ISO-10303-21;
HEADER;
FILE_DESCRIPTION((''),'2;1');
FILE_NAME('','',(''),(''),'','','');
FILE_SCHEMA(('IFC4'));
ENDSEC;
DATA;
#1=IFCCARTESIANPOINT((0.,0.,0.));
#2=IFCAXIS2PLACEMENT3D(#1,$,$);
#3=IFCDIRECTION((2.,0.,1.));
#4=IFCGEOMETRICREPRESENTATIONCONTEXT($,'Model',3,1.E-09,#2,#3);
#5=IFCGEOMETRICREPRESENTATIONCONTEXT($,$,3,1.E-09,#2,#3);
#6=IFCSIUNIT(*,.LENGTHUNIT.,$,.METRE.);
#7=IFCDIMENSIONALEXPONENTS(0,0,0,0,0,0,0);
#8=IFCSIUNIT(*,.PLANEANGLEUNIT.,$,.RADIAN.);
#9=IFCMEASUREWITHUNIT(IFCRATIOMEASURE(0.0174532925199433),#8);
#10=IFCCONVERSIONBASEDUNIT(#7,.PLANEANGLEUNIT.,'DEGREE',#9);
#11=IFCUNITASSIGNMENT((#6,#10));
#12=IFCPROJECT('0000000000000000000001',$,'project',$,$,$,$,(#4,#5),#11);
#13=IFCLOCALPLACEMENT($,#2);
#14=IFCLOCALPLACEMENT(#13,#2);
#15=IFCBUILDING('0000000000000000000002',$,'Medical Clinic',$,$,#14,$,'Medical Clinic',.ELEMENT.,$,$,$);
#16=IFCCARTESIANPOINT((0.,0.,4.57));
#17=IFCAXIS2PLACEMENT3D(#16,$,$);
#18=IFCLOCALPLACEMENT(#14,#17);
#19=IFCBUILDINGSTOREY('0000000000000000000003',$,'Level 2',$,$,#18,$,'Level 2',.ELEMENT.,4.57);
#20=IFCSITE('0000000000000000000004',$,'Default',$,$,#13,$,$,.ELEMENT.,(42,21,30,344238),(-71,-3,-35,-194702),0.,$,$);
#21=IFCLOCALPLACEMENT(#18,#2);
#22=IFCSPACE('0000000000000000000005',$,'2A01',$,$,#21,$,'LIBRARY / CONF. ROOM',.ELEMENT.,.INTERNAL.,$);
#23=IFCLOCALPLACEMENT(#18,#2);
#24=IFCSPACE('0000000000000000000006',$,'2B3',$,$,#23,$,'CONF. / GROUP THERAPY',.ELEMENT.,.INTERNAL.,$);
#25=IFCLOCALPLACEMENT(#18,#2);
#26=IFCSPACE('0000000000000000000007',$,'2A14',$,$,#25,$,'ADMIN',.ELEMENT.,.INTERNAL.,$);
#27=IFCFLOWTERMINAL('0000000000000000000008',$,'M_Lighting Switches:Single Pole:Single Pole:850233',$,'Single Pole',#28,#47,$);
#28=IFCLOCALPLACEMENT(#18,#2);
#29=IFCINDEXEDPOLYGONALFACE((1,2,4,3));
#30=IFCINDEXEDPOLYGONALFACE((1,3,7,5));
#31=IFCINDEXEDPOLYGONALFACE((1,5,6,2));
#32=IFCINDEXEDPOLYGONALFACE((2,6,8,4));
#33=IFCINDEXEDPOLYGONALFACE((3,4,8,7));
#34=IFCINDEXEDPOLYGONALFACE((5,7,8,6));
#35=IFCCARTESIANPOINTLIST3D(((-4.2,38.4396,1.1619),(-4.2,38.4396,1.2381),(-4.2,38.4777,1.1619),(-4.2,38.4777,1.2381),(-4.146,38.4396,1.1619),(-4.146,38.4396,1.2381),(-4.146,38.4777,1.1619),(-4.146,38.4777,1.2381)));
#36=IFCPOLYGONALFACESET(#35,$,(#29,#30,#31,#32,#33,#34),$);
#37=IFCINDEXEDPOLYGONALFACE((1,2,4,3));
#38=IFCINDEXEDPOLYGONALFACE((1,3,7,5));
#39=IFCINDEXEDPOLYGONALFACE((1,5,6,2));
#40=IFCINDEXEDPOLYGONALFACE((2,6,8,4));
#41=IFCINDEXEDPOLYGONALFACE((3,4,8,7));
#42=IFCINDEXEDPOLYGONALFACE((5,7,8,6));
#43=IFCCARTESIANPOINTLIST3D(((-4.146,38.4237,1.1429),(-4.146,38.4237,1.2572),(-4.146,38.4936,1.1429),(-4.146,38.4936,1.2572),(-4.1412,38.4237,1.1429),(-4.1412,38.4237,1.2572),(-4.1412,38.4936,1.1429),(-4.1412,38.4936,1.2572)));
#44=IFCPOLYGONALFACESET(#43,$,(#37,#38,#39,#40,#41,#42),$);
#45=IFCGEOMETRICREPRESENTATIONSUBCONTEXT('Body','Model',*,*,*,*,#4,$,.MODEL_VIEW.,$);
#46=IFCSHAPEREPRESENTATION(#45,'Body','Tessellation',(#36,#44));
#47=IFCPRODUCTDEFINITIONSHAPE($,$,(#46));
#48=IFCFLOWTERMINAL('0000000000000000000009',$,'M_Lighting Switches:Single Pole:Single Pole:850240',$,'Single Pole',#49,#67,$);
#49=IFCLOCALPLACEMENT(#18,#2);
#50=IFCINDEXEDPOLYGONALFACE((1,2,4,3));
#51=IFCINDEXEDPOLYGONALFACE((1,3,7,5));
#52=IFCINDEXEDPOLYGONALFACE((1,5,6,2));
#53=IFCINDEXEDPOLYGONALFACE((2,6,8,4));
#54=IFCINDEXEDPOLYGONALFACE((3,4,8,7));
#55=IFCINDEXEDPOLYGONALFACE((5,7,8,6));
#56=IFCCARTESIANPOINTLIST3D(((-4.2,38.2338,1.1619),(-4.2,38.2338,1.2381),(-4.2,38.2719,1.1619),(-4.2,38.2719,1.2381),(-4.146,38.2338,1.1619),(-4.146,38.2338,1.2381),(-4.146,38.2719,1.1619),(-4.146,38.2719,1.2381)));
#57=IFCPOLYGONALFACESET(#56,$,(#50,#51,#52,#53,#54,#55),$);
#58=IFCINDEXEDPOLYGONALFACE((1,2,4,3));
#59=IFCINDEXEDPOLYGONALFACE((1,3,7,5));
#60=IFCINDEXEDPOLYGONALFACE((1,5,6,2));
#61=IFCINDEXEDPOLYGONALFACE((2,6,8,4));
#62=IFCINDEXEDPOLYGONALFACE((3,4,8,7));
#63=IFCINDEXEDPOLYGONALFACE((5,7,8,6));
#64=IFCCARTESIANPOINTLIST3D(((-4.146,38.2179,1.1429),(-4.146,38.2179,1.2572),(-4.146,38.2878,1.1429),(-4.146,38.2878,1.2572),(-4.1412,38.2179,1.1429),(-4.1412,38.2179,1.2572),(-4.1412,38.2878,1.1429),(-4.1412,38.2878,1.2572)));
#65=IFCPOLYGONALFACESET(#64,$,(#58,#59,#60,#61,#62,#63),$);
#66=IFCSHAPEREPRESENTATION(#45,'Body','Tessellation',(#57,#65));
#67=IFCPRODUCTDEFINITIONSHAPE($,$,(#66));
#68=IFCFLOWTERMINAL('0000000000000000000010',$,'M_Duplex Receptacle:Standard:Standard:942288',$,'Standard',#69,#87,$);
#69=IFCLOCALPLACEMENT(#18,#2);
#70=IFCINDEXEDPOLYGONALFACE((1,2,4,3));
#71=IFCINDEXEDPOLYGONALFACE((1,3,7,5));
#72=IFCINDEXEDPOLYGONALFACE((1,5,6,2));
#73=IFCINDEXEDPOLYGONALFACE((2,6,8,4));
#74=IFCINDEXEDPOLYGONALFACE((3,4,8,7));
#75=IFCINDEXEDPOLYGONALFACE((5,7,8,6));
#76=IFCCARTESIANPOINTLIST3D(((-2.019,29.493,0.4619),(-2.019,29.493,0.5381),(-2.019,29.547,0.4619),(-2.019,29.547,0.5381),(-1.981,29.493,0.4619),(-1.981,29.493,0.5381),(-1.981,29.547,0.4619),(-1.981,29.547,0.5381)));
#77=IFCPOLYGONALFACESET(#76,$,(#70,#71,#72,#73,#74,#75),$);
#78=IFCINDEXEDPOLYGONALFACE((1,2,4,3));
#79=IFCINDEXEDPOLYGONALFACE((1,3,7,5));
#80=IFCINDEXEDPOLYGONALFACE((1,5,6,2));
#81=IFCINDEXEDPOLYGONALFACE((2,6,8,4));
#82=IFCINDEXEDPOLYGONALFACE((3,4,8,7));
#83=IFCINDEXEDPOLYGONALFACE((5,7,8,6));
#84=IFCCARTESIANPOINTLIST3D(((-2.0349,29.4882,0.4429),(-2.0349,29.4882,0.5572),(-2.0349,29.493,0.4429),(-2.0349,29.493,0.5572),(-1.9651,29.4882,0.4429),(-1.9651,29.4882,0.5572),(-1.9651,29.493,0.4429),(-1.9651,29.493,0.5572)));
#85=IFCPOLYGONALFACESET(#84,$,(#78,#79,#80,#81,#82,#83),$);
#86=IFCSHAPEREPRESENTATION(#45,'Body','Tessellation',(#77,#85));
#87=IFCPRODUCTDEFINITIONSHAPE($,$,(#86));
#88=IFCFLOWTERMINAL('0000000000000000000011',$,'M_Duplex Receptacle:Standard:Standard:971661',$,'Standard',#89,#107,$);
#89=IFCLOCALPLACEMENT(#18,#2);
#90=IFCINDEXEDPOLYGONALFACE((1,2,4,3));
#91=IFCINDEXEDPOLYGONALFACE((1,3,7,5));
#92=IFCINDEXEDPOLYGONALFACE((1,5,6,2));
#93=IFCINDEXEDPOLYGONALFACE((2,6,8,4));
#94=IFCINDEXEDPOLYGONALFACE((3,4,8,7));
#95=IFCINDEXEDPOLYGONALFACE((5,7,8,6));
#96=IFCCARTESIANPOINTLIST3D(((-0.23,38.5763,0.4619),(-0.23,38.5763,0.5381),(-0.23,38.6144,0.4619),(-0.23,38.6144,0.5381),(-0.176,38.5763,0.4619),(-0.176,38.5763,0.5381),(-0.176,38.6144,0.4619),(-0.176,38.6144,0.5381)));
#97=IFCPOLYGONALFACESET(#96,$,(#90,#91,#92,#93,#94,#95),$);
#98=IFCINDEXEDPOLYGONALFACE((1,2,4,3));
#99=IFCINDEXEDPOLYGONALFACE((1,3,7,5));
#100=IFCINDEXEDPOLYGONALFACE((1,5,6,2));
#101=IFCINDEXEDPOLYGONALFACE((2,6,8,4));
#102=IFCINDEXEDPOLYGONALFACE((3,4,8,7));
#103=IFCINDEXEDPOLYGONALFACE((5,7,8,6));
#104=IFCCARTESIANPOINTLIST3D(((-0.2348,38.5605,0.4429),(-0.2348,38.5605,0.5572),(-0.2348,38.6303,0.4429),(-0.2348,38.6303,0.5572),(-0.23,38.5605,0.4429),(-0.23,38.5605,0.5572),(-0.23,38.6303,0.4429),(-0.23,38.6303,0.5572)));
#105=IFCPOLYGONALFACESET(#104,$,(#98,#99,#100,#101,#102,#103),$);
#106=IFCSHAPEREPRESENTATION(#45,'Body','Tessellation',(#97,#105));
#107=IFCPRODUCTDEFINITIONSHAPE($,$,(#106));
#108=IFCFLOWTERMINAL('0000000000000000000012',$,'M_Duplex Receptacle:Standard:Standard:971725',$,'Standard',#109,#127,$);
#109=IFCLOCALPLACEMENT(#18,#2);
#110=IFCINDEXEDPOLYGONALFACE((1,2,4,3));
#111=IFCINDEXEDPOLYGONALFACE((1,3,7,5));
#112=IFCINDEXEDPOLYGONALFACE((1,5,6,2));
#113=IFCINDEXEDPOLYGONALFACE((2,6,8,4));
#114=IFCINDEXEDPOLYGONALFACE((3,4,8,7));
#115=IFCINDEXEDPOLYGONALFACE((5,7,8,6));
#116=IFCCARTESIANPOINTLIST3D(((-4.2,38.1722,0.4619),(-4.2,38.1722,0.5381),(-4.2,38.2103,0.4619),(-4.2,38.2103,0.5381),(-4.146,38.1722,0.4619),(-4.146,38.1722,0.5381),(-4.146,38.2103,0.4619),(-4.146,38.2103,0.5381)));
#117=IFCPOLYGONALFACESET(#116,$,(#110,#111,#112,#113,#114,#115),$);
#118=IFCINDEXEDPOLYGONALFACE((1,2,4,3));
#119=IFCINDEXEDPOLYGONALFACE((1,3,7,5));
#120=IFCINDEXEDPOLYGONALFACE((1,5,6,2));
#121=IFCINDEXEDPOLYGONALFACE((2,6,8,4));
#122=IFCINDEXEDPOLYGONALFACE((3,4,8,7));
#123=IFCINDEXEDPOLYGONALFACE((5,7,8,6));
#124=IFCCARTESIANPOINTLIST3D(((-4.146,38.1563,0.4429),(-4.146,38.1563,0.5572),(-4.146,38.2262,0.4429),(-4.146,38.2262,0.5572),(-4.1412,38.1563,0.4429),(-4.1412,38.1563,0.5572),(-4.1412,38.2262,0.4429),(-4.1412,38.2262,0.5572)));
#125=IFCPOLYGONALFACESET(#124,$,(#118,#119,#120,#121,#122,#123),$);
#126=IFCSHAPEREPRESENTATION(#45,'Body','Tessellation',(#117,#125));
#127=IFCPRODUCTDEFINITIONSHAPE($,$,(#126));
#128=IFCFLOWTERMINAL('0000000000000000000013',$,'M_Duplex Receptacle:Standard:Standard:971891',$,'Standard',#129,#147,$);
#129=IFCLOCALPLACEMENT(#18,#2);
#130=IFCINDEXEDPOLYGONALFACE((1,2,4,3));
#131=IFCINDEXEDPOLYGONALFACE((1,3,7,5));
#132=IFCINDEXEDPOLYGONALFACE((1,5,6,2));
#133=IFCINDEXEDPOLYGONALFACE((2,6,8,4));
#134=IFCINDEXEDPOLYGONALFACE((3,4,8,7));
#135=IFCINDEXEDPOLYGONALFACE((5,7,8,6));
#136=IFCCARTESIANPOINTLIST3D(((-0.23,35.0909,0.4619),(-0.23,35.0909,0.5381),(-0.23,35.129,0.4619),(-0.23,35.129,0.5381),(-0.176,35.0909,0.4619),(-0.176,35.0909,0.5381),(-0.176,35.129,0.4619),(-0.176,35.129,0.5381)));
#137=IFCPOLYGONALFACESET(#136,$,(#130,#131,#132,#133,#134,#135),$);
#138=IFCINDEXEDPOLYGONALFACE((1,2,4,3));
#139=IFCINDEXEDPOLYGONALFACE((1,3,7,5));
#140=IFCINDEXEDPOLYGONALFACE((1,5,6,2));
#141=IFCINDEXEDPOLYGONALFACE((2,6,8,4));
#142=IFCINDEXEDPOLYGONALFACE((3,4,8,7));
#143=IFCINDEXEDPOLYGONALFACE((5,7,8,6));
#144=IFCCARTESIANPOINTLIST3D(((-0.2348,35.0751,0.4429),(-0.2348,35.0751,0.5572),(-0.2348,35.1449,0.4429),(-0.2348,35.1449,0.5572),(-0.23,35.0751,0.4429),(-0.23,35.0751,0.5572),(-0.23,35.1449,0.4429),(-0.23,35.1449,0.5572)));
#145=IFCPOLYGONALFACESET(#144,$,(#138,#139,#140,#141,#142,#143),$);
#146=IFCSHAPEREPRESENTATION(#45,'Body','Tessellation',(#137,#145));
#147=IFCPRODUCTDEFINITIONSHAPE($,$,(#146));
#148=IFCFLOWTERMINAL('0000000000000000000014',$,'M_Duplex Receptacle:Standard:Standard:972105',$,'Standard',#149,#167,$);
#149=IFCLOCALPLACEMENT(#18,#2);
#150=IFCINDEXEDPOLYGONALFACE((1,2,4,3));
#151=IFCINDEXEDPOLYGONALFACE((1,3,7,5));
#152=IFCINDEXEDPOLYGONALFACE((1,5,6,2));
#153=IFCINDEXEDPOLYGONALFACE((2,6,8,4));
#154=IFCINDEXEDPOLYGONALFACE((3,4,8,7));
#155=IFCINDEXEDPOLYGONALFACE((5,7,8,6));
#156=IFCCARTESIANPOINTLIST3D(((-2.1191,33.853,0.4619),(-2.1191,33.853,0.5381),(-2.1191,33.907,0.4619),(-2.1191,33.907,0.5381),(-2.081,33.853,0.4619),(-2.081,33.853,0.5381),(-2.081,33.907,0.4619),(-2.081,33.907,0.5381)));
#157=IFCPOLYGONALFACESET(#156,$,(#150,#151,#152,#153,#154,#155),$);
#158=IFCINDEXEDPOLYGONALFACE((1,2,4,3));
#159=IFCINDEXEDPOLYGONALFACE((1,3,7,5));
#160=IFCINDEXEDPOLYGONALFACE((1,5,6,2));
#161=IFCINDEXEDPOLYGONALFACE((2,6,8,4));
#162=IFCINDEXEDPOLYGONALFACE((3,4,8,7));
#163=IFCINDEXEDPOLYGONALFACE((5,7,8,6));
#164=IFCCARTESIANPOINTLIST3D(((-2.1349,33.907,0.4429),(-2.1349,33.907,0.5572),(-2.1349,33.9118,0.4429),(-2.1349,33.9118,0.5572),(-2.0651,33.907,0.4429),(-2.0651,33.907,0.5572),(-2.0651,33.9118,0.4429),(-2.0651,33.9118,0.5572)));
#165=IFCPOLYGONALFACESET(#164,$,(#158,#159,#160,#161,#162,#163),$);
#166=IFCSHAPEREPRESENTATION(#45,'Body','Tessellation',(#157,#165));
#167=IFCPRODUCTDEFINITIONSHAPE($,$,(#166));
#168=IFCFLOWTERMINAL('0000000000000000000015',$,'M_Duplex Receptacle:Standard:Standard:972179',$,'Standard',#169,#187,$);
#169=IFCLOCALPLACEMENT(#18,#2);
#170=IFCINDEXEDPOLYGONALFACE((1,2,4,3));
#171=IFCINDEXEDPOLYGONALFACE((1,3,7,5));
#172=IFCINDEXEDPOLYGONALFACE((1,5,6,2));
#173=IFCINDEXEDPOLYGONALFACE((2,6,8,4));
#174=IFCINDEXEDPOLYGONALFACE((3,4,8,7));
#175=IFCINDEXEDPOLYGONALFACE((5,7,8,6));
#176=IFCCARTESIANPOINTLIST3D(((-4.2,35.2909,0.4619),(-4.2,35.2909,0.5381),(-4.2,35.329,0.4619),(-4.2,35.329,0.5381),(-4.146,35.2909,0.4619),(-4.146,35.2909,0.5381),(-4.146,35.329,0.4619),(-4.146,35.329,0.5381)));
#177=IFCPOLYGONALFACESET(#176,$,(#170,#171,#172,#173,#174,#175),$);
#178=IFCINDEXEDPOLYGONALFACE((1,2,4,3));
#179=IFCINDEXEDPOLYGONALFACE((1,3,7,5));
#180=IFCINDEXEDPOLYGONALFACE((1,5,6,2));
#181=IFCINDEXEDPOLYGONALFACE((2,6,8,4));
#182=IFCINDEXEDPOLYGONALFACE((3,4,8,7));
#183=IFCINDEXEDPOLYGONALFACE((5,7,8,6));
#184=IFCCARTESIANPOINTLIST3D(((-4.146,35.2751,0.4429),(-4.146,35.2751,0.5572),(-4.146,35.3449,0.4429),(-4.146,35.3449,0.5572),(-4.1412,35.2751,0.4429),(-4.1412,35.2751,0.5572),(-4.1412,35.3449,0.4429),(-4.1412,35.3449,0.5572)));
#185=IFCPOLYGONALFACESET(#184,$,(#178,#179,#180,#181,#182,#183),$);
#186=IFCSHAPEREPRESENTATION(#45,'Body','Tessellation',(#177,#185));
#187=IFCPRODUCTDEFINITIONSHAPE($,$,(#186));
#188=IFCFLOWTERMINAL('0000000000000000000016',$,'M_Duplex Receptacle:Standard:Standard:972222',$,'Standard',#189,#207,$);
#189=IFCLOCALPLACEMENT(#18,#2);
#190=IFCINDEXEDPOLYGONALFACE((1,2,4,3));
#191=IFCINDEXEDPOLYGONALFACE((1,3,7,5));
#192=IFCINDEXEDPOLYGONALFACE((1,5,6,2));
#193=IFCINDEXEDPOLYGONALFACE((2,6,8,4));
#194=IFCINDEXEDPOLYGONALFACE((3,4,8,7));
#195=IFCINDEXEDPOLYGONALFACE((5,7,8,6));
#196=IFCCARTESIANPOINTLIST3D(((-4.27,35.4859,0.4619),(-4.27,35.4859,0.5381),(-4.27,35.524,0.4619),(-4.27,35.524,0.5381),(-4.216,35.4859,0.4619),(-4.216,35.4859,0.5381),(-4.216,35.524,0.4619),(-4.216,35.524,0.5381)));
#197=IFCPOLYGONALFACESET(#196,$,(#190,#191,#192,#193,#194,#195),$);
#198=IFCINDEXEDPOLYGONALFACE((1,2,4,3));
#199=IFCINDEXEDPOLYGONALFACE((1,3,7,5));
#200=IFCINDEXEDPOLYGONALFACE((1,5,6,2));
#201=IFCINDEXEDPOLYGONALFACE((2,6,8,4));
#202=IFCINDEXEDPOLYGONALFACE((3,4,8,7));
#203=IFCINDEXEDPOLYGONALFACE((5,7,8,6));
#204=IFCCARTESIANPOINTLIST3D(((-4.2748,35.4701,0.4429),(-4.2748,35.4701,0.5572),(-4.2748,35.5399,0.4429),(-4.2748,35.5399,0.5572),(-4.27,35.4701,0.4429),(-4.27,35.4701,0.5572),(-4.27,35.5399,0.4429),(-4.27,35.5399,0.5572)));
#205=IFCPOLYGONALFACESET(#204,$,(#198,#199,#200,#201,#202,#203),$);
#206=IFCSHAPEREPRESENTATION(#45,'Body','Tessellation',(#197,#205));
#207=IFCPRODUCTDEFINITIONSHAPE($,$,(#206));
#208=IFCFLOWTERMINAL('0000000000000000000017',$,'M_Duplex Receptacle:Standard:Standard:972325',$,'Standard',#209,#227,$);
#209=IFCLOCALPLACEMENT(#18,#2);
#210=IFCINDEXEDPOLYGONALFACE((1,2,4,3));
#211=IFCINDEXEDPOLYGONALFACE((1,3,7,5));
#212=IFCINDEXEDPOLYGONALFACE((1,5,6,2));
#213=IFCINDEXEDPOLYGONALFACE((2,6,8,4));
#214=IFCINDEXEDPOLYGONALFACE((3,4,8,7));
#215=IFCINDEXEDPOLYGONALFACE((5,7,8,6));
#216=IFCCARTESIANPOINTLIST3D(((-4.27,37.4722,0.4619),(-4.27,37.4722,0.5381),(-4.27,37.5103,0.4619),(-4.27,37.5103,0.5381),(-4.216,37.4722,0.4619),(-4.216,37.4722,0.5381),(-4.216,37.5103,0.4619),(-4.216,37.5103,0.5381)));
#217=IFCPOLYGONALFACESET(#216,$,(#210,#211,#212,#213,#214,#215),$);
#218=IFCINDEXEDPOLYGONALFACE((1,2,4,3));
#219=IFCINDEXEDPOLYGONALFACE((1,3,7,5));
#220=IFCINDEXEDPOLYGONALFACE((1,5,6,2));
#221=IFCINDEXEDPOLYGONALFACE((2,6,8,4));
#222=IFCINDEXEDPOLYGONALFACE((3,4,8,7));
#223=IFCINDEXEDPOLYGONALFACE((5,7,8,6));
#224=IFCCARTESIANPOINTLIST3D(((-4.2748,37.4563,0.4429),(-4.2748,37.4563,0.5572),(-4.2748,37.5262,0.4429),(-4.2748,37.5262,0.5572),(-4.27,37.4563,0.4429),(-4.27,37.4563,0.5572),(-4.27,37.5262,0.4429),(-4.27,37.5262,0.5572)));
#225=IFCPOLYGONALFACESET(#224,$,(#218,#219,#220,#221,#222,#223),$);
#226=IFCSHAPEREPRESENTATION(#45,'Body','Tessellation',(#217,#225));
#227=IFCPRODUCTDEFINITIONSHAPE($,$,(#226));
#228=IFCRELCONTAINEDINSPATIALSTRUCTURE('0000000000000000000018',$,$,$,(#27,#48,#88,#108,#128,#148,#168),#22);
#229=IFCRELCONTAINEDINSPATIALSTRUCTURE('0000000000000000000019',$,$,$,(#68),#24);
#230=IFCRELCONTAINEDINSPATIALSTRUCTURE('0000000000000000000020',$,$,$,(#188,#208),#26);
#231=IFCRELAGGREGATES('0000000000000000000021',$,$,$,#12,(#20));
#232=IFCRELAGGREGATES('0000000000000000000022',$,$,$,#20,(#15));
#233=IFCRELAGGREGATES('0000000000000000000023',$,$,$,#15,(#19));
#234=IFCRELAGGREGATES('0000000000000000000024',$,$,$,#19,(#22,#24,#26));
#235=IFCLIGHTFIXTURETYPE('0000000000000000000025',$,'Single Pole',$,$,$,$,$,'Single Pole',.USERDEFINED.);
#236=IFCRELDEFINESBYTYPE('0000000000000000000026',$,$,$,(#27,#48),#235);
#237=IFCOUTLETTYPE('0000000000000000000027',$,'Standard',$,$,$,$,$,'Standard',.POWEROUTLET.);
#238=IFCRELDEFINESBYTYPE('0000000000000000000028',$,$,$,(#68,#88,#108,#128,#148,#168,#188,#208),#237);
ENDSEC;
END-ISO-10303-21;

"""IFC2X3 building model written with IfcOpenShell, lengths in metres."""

from ifc_helpers import new_model, entity, si_unit, converted_unit, direction, frame, frame_2d, origin, origin_2d_with_axis, place, context, subcontext, project, spatial, rectangle, extrude, source, transform, mapped, type_object, type_shapes, element, save


model = new_model("IFC2X3")

# Units and contexts
model_context = context("Model", 3, precision=1e-09, world=origin(), true_north=direction((2.0, 0.0, 1.0)))
context_of_model = context(None, 3, precision=1e-09, world=origin(), true_north=direction((2.0, 0.0, 1.0)))
body_context = subcontext(model_context, "Body", "Model", "MODEL_VIEW")
ifc_project = project(units=[si_unit("LENGTHUNIT", "METRE"), converted_unit("PLANEANGLEUNIT", "DEGREE", entity("IfcRatioMeasure", 0.0174532925199433), si_unit("PLANEANGLEUNIT", "RADIAN"), dimensions=[0, 0, 0, 0, 0, 0, 0])], contexts=[model_context, context_of_model])

# Site, building, storey, space
site_placement = place(None, origin())
site = spatial("IfcSite", under=ifc_project, at=site_placement, Name="Default", CompositionType="ELEMENT", RefLatitude=(42, 21, 30, 344238), RefLongitude=(-71, -3, -35, -194702), RefElevation=0.0)
building_placement = place(site_placement, origin())
building = spatial("IfcBuilding", under=site, at=building_placement, Name="Medical Clinic", LongName="Medical Clinic", CompositionType="ELEMENT")
storey_placement = place(building_placement, frame((0.0, 0.0, 4.57)))
storey = spatial("IfcBuildingStorey", under=building, at=storey_placement, Name="Level 2", LongName="Level 2", CompositionType="ELEMENT", Elevation=4.57)
space_1_placement = place(storey_placement, origin())
space_1 = spatial("IfcSpace", under=storey, at=space_1_placement, Name="2A01", LongName="LIBRARY / CONF. ROOM", CompositionType="ELEMENT", InteriorOrExteriorSpace="INTERNAL")

# Flow terminals
light_fixture_type_1 = type_object("IfcLightFixtureType", Name="Single Pole", ElementType="Single Pole", PredefinedType="USERDEFINED")
shared_shape_1 = source(origin(), body_context, "Body", "SweptSolid", [
    extrude(rectangle(XDim=0.0381, YDim=0.0762, at=origin_2d_with_axis()), frame((0.0, 0.0, -0.054), z_axis=(0.0, 0.0, 1.0), x_axis=(-1.0, 0.0, 0.0)), (0.0, 0.0, 1.0), 0.054),
    extrude(rectangle(XDim=0.0698, YDim=0.1143, at=frame_2d((0.0, 0.0), x_axis=(1.0, 0.0))), frame((0.0, 0.0, 0.0), z_axis=(0.0, 0.0, 1.0), x_axis=(-1.0, 0.0, 0.0)), (0.0, 0.0, 1.0), 0.0048),
])
type_shapes(light_fixture_type_1, [shared_shape_1])
for number, where, z_axis, x_axis, name in (
    (1, (-4.146, 38.4586, 1.2), (1.0, 0.0, 0.0), (0.0, 1.0, 0.0), "M_Lighting Switches:Single Pole:Single Pole:850233"),
    (2, (-4.146, 38.2528, 1.2), (1.0, 0.0, 0.0), (0.0, 1.0, 0.0), "M_Lighting Switches:Single Pole:Single Pole:850240"),
):
    element("IfcFlowTerminal", number, at=place(space_1_placement, frame(where, z_axis=z_axis, x_axis=x_axis)), inside=space_1, type_object=light_fixture_type_1, Name=name, ObjectType="Single Pole", context=body_context, shape_type="MappedRepresentation", body=[
        mapped(shared_shape_1, transform((0.0, 0.0, 0.0), scale=1.0)),
    ])

# Shared definitions
space_2_placement = place(storey_placement, origin())
space_2 = spatial("IfcSpace", under=storey, at=space_2_placement, Name="2B3", LongName="CONF. / GROUP THERAPY", CompositionType="ELEMENT", InteriorOrExteriorSpace="INTERNAL")

# Flow terminals
outlet_type = type_object("IfcOutletType", Name="Standard", ElementType="Standard", PredefinedType="POWEROUTLET")
shared_shape_2 = source(origin(), body_context, "Body", "SweptSolid", [
    extrude(rectangle(XDim=0.0381, YDim=0.0762, at=origin_2d_with_axis()), frame((0.0, 0.0, -0.054), z_axis=(0.0, 0.0, 1.0), x_axis=(-1.0, 0.0, 0.0)), (0.0, 0.0, 1.0), 0.054),
    extrude(rectangle(XDim=0.0698, YDim=0.1143, at=frame_2d((0.0, 0.0), x_axis=(1.0, 0.0))), frame((0.0, 0.0, 0.0), z_axis=(0.0, 0.0, 1.0), x_axis=(-1.0, 0.0, 0.0)), (0.0, 0.0, 1.0), 0.0048),
])
type_shapes(outlet_type, [shared_shape_2])
flow_terminal_1_placement = place(space_2_placement, frame((-2.0, 29.493, 0.5), z_axis=(0.0, -1.0, 0.0), x_axis=(1.0, 0.0, 0.0)))
element("IfcFlowTerminal", 3, at=flow_terminal_1_placement, inside=space_2, type_object=outlet_type, Name="M_Duplex Receptacle:Standard:Standard:942288", ObjectType="Standard", context=body_context, shape_type="MappedRepresentation", body=[
    mapped(shared_shape_2, transform((0.0, 0.0, 0.0), scale=1.0)),
])
for number, where, z_axis, x_axis, name in (
    (4, (-0.23, 38.5954, 0.5), (-1.0, 0.0, 0.0), (0.0, -1.0, 0.0), "M_Duplex Receptacle:Standard:Standard:971661"),
    (5, (-4.146, 38.1912, 0.5), (1.0, 0.0, 0.0), (0.0, 1.0, 0.0), "M_Duplex Receptacle:Standard:Standard:971725"),
    (6, (-0.23, 35.11, 0.5), (-1.0, 0.0, 0.0), (0.0, -1.0, 0.0), "M_Duplex Receptacle:Standard:Standard:971891"),
    (7, (-2.1, 33.907, 0.5), (0.0, 1.0, 0.0), (-1.0, 0.0, 0.0), "M_Duplex Receptacle:Standard:Standard:972105"),
    (8, (-4.146, 35.31, 0.5), (1.0, 0.0, 0.0), (0.0, 1.0, 0.0), "M_Duplex Receptacle:Standard:Standard:972179"),
):
    element("IfcFlowTerminal", number, at=place(space_1_placement, frame(where, z_axis=z_axis, x_axis=x_axis)), inside=space_1, type_object=outlet_type, Name=name, ObjectType="Standard", context=body_context, shape_type="MappedRepresentation", body=[
        mapped(shared_shape_2, transform((0.0, 0.0, 0.0), scale=1.0)),
    ])

# Shared definitions
space_3_placement = place(storey_placement, origin())
space_3 = spatial("IfcSpace", under=storey, at=space_3_placement, Name="2A14", LongName="ADMIN", CompositionType="ELEMENT", InteriorOrExteriorSpace="INTERNAL")

# Flow terminals
for number, where, z_axis, x_axis, name in (
    (9, (-4.27, 35.505, 0.5), (-1.0, 0.0, 0.0), (0.0, -1.0, 0.0), "M_Duplex Receptacle:Standard:Standard:972222"),
    (10, (-4.27, 37.4912, 0.5), (-1.0, 0.0, 0.0), (0.0, -1.0, 0.0), "M_Duplex Receptacle:Standard:Standard:972325"),
):
    element("IfcFlowTerminal", number, at=place(space_3_placement, frame(where, z_axis=z_axis, x_axis=x_axis)), inside=space_3, type_object=outlet_type, Name=name, ObjectType="Standard", context=body_context, shape_type="MappedRepresentation", body=[
        mapped(shared_shape_2, transform((0.0, 0.0, 0.0), scale=1.0)),
    ])

save(model, "model.ifc")
